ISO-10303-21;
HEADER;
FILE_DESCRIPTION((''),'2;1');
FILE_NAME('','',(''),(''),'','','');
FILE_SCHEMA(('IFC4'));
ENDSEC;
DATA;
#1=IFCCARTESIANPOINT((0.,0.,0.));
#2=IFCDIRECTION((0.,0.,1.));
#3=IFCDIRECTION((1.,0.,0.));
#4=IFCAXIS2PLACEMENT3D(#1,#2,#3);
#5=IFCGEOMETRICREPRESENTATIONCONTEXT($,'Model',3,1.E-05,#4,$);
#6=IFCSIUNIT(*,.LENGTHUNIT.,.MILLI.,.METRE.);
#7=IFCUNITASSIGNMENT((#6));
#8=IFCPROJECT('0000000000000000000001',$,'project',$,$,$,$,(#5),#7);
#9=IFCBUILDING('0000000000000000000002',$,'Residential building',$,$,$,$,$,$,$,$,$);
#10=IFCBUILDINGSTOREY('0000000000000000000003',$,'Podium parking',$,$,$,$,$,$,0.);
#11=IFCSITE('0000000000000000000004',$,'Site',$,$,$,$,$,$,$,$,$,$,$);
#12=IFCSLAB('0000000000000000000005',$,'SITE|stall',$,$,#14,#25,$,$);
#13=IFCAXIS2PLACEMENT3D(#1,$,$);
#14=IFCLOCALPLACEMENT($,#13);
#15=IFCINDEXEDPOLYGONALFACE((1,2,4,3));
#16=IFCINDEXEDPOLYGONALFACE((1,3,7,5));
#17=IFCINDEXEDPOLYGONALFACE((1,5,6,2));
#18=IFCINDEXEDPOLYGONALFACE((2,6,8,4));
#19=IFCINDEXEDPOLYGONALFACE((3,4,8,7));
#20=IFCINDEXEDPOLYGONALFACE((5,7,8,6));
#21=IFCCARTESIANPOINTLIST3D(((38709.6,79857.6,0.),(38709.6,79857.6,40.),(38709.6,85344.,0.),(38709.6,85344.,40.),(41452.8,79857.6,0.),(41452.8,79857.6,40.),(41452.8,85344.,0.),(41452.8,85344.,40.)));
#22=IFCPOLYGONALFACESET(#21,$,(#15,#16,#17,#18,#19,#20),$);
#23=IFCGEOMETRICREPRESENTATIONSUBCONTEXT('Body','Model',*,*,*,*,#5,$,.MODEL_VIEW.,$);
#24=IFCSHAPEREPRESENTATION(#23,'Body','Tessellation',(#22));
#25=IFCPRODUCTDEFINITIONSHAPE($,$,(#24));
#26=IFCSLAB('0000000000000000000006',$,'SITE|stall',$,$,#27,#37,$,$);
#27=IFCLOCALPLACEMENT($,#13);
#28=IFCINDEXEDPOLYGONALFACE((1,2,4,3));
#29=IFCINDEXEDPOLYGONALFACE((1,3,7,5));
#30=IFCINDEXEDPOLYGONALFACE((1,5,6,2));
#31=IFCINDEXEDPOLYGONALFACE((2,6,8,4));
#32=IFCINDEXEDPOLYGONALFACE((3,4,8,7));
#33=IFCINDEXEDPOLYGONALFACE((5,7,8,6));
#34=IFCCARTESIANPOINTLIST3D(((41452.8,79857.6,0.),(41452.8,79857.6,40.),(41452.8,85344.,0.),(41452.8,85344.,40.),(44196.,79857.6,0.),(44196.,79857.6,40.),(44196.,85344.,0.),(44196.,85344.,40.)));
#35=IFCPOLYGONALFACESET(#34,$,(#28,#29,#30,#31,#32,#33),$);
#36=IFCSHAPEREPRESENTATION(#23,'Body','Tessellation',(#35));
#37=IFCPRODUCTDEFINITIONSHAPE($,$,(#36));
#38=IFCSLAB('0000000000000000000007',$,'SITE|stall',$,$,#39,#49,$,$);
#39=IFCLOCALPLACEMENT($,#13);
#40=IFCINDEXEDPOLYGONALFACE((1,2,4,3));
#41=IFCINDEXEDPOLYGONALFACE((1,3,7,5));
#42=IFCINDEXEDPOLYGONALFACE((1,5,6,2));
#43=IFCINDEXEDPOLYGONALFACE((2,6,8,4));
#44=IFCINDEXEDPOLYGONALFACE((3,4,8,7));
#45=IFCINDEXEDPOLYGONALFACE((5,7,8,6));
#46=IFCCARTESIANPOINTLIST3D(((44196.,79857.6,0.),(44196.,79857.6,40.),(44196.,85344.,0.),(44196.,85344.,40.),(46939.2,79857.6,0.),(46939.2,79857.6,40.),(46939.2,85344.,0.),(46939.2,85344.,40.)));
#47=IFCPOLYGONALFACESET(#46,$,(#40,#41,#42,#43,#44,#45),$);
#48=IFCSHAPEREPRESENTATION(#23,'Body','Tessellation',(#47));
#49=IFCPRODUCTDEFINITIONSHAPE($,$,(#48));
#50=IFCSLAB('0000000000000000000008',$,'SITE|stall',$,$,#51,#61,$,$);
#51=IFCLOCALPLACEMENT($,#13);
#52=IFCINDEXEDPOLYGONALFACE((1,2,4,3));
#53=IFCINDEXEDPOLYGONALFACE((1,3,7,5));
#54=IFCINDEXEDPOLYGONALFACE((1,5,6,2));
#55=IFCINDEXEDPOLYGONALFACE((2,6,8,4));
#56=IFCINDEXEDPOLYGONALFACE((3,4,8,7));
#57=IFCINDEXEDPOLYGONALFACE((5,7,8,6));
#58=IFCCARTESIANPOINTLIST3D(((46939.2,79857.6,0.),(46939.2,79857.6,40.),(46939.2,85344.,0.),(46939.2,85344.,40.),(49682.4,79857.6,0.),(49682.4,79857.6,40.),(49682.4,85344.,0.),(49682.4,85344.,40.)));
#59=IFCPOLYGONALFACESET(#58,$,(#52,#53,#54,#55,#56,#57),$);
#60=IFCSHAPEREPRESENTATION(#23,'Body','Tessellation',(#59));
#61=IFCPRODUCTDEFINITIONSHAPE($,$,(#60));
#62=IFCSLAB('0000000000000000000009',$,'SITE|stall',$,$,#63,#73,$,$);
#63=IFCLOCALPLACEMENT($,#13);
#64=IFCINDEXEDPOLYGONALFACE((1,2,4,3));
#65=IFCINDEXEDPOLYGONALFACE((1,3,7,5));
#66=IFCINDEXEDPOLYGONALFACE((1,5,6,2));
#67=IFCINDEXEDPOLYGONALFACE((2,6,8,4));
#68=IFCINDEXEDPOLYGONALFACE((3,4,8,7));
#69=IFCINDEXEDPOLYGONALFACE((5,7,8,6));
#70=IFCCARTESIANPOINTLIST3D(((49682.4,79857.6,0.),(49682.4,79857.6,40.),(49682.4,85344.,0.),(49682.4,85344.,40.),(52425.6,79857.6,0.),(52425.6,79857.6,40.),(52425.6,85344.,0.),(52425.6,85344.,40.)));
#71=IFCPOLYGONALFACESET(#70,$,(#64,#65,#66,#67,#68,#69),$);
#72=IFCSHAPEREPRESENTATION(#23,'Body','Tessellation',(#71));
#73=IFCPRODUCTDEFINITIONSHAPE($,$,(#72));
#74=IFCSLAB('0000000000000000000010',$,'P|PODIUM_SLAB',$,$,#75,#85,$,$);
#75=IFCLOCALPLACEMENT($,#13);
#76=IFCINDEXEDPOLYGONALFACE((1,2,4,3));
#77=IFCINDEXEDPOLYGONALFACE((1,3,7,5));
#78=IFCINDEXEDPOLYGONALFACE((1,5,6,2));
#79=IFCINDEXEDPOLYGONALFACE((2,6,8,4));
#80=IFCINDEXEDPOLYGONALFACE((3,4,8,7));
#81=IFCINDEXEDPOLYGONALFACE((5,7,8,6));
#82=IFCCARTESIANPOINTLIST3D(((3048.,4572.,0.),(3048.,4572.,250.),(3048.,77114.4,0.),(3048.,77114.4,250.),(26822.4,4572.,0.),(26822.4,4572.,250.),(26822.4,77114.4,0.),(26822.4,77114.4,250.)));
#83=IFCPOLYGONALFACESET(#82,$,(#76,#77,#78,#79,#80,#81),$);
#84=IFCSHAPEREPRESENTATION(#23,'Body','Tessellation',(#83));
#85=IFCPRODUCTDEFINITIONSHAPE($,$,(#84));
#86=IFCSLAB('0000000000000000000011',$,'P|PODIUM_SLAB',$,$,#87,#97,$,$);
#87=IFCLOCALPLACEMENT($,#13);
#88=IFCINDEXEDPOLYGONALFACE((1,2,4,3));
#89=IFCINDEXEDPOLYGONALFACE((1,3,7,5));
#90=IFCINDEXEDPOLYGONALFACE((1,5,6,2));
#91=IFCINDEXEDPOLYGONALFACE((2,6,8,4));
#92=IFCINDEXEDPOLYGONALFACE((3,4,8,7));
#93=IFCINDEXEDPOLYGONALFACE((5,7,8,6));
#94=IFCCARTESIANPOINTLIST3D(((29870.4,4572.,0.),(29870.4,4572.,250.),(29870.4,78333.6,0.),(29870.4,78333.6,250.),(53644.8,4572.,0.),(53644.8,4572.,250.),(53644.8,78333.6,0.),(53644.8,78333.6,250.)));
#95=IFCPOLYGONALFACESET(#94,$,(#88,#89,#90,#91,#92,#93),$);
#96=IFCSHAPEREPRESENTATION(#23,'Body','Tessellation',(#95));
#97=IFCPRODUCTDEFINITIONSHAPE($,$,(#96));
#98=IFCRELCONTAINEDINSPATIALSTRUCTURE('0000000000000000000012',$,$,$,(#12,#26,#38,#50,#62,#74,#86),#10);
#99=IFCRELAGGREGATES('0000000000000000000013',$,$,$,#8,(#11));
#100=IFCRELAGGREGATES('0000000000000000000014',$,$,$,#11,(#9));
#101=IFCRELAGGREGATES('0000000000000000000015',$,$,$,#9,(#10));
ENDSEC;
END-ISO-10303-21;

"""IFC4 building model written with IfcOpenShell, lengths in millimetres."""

from ifc_helpers import new_model, si_unit, frame, origin_with_axes, place, context, subcontext, project, spatial, indexed_curve, outline, extrude, element, save


model = new_model("IFC4")

# Units and contexts
model_context = context("Model", 3, precision=1e-05, world=origin_with_axes())
body_context = subcontext(model_context, "Body", "Model", "MODEL_VIEW")
ifc_project = project(units=[si_unit("LENGTHUNIT", "METRE", prefix="MILLI")], contexts=[model_context])

# Site, building, storey
site = spatial("IfcSite", under=ifc_project, Name="Site")
building = spatial("IfcBuilding", under=site, Name="Residential building")
storey = spatial("IfcBuildingStorey", under=building, Name="Podium parking", Elevation=0.0)

# Slabs
for number, where, z_axis, x_axis, name in (
    (1, (38709.6, 79857.6, 0.0), (0.0, 0.0, 1.0), (1.0, 0.0, 0.0), "SITE|stall"),
    (2, (41452.8, 79857.6, 0.0), (0.0, 0.0, 1.0), (1.0, 0.0, 0.0), "SITE|stall"),
    (3, (44196.0, 79857.6, 0.0), (0.0, 0.0, 1.0), (1.0, 0.0, 0.0), "SITE|stall"),
    (4, (46939.2, 79857.6, 0.0), (0.0, 0.0, 1.0), (1.0, 0.0, 0.0), "SITE|stall"),
    (5, (49682.4, 79857.6, 0.0), (0.0, 0.0, 1.0), (1.0, 0.0, 0.0), "SITE|stall"),
):
    element("IfcSlab", number, at=place(None, frame(where, z_axis=z_axis, x_axis=x_axis)), inside=storey, Name=name, context=body_context, shape_type="SweptSolid", body=[
        extrude(outline(indexed_curve([(0.0, 0.0), (2743.2, 0.0), (2743.2, 5486.4), (0.0, 5486.4), (0.0, 0.0)])), None, (0.0, 0.0, 1.0), 40.0),
    ])
slab_1_placement = place(None, frame((3048.0, 4572.0, 0.0), z_axis=(0.0, 0.0, 1.0), x_axis=(1.0, 0.0, 0.0)))
element("IfcSlab", 6, at=slab_1_placement, inside=storey, Name="P|PODIUM_SLAB", context=body_context, shape_type="SweptSolid", body=[
    extrude(outline(indexed_curve([(0.0, 0.0), (23774.4, 0.0), (23774.4, 72542.4), (0.0, 72542.4), (0.0, 0.0)])), None, (0.0, 0.0, 1.0), 250.0),
])
slab_2_placement = place(None, frame((29870.4, 4572.0, 0.0), z_axis=(0.0, 0.0, 1.0), x_axis=(1.0, 0.0, 0.0)))
element("IfcSlab", 7, at=slab_2_placement, inside=storey, Name="P|PODIUM_SLAB", context=body_context, shape_type="SweptSolid", body=[
    extrude(outline(indexed_curve([(0.0, 0.0), (23774.4, 0.0), (23774.4, 73761.6), (0.0, 73761.6), (0.0, 0.0)])), None, (0.0, 0.0, 1.0), 250.0),
])

save(model, "model.ifc")
